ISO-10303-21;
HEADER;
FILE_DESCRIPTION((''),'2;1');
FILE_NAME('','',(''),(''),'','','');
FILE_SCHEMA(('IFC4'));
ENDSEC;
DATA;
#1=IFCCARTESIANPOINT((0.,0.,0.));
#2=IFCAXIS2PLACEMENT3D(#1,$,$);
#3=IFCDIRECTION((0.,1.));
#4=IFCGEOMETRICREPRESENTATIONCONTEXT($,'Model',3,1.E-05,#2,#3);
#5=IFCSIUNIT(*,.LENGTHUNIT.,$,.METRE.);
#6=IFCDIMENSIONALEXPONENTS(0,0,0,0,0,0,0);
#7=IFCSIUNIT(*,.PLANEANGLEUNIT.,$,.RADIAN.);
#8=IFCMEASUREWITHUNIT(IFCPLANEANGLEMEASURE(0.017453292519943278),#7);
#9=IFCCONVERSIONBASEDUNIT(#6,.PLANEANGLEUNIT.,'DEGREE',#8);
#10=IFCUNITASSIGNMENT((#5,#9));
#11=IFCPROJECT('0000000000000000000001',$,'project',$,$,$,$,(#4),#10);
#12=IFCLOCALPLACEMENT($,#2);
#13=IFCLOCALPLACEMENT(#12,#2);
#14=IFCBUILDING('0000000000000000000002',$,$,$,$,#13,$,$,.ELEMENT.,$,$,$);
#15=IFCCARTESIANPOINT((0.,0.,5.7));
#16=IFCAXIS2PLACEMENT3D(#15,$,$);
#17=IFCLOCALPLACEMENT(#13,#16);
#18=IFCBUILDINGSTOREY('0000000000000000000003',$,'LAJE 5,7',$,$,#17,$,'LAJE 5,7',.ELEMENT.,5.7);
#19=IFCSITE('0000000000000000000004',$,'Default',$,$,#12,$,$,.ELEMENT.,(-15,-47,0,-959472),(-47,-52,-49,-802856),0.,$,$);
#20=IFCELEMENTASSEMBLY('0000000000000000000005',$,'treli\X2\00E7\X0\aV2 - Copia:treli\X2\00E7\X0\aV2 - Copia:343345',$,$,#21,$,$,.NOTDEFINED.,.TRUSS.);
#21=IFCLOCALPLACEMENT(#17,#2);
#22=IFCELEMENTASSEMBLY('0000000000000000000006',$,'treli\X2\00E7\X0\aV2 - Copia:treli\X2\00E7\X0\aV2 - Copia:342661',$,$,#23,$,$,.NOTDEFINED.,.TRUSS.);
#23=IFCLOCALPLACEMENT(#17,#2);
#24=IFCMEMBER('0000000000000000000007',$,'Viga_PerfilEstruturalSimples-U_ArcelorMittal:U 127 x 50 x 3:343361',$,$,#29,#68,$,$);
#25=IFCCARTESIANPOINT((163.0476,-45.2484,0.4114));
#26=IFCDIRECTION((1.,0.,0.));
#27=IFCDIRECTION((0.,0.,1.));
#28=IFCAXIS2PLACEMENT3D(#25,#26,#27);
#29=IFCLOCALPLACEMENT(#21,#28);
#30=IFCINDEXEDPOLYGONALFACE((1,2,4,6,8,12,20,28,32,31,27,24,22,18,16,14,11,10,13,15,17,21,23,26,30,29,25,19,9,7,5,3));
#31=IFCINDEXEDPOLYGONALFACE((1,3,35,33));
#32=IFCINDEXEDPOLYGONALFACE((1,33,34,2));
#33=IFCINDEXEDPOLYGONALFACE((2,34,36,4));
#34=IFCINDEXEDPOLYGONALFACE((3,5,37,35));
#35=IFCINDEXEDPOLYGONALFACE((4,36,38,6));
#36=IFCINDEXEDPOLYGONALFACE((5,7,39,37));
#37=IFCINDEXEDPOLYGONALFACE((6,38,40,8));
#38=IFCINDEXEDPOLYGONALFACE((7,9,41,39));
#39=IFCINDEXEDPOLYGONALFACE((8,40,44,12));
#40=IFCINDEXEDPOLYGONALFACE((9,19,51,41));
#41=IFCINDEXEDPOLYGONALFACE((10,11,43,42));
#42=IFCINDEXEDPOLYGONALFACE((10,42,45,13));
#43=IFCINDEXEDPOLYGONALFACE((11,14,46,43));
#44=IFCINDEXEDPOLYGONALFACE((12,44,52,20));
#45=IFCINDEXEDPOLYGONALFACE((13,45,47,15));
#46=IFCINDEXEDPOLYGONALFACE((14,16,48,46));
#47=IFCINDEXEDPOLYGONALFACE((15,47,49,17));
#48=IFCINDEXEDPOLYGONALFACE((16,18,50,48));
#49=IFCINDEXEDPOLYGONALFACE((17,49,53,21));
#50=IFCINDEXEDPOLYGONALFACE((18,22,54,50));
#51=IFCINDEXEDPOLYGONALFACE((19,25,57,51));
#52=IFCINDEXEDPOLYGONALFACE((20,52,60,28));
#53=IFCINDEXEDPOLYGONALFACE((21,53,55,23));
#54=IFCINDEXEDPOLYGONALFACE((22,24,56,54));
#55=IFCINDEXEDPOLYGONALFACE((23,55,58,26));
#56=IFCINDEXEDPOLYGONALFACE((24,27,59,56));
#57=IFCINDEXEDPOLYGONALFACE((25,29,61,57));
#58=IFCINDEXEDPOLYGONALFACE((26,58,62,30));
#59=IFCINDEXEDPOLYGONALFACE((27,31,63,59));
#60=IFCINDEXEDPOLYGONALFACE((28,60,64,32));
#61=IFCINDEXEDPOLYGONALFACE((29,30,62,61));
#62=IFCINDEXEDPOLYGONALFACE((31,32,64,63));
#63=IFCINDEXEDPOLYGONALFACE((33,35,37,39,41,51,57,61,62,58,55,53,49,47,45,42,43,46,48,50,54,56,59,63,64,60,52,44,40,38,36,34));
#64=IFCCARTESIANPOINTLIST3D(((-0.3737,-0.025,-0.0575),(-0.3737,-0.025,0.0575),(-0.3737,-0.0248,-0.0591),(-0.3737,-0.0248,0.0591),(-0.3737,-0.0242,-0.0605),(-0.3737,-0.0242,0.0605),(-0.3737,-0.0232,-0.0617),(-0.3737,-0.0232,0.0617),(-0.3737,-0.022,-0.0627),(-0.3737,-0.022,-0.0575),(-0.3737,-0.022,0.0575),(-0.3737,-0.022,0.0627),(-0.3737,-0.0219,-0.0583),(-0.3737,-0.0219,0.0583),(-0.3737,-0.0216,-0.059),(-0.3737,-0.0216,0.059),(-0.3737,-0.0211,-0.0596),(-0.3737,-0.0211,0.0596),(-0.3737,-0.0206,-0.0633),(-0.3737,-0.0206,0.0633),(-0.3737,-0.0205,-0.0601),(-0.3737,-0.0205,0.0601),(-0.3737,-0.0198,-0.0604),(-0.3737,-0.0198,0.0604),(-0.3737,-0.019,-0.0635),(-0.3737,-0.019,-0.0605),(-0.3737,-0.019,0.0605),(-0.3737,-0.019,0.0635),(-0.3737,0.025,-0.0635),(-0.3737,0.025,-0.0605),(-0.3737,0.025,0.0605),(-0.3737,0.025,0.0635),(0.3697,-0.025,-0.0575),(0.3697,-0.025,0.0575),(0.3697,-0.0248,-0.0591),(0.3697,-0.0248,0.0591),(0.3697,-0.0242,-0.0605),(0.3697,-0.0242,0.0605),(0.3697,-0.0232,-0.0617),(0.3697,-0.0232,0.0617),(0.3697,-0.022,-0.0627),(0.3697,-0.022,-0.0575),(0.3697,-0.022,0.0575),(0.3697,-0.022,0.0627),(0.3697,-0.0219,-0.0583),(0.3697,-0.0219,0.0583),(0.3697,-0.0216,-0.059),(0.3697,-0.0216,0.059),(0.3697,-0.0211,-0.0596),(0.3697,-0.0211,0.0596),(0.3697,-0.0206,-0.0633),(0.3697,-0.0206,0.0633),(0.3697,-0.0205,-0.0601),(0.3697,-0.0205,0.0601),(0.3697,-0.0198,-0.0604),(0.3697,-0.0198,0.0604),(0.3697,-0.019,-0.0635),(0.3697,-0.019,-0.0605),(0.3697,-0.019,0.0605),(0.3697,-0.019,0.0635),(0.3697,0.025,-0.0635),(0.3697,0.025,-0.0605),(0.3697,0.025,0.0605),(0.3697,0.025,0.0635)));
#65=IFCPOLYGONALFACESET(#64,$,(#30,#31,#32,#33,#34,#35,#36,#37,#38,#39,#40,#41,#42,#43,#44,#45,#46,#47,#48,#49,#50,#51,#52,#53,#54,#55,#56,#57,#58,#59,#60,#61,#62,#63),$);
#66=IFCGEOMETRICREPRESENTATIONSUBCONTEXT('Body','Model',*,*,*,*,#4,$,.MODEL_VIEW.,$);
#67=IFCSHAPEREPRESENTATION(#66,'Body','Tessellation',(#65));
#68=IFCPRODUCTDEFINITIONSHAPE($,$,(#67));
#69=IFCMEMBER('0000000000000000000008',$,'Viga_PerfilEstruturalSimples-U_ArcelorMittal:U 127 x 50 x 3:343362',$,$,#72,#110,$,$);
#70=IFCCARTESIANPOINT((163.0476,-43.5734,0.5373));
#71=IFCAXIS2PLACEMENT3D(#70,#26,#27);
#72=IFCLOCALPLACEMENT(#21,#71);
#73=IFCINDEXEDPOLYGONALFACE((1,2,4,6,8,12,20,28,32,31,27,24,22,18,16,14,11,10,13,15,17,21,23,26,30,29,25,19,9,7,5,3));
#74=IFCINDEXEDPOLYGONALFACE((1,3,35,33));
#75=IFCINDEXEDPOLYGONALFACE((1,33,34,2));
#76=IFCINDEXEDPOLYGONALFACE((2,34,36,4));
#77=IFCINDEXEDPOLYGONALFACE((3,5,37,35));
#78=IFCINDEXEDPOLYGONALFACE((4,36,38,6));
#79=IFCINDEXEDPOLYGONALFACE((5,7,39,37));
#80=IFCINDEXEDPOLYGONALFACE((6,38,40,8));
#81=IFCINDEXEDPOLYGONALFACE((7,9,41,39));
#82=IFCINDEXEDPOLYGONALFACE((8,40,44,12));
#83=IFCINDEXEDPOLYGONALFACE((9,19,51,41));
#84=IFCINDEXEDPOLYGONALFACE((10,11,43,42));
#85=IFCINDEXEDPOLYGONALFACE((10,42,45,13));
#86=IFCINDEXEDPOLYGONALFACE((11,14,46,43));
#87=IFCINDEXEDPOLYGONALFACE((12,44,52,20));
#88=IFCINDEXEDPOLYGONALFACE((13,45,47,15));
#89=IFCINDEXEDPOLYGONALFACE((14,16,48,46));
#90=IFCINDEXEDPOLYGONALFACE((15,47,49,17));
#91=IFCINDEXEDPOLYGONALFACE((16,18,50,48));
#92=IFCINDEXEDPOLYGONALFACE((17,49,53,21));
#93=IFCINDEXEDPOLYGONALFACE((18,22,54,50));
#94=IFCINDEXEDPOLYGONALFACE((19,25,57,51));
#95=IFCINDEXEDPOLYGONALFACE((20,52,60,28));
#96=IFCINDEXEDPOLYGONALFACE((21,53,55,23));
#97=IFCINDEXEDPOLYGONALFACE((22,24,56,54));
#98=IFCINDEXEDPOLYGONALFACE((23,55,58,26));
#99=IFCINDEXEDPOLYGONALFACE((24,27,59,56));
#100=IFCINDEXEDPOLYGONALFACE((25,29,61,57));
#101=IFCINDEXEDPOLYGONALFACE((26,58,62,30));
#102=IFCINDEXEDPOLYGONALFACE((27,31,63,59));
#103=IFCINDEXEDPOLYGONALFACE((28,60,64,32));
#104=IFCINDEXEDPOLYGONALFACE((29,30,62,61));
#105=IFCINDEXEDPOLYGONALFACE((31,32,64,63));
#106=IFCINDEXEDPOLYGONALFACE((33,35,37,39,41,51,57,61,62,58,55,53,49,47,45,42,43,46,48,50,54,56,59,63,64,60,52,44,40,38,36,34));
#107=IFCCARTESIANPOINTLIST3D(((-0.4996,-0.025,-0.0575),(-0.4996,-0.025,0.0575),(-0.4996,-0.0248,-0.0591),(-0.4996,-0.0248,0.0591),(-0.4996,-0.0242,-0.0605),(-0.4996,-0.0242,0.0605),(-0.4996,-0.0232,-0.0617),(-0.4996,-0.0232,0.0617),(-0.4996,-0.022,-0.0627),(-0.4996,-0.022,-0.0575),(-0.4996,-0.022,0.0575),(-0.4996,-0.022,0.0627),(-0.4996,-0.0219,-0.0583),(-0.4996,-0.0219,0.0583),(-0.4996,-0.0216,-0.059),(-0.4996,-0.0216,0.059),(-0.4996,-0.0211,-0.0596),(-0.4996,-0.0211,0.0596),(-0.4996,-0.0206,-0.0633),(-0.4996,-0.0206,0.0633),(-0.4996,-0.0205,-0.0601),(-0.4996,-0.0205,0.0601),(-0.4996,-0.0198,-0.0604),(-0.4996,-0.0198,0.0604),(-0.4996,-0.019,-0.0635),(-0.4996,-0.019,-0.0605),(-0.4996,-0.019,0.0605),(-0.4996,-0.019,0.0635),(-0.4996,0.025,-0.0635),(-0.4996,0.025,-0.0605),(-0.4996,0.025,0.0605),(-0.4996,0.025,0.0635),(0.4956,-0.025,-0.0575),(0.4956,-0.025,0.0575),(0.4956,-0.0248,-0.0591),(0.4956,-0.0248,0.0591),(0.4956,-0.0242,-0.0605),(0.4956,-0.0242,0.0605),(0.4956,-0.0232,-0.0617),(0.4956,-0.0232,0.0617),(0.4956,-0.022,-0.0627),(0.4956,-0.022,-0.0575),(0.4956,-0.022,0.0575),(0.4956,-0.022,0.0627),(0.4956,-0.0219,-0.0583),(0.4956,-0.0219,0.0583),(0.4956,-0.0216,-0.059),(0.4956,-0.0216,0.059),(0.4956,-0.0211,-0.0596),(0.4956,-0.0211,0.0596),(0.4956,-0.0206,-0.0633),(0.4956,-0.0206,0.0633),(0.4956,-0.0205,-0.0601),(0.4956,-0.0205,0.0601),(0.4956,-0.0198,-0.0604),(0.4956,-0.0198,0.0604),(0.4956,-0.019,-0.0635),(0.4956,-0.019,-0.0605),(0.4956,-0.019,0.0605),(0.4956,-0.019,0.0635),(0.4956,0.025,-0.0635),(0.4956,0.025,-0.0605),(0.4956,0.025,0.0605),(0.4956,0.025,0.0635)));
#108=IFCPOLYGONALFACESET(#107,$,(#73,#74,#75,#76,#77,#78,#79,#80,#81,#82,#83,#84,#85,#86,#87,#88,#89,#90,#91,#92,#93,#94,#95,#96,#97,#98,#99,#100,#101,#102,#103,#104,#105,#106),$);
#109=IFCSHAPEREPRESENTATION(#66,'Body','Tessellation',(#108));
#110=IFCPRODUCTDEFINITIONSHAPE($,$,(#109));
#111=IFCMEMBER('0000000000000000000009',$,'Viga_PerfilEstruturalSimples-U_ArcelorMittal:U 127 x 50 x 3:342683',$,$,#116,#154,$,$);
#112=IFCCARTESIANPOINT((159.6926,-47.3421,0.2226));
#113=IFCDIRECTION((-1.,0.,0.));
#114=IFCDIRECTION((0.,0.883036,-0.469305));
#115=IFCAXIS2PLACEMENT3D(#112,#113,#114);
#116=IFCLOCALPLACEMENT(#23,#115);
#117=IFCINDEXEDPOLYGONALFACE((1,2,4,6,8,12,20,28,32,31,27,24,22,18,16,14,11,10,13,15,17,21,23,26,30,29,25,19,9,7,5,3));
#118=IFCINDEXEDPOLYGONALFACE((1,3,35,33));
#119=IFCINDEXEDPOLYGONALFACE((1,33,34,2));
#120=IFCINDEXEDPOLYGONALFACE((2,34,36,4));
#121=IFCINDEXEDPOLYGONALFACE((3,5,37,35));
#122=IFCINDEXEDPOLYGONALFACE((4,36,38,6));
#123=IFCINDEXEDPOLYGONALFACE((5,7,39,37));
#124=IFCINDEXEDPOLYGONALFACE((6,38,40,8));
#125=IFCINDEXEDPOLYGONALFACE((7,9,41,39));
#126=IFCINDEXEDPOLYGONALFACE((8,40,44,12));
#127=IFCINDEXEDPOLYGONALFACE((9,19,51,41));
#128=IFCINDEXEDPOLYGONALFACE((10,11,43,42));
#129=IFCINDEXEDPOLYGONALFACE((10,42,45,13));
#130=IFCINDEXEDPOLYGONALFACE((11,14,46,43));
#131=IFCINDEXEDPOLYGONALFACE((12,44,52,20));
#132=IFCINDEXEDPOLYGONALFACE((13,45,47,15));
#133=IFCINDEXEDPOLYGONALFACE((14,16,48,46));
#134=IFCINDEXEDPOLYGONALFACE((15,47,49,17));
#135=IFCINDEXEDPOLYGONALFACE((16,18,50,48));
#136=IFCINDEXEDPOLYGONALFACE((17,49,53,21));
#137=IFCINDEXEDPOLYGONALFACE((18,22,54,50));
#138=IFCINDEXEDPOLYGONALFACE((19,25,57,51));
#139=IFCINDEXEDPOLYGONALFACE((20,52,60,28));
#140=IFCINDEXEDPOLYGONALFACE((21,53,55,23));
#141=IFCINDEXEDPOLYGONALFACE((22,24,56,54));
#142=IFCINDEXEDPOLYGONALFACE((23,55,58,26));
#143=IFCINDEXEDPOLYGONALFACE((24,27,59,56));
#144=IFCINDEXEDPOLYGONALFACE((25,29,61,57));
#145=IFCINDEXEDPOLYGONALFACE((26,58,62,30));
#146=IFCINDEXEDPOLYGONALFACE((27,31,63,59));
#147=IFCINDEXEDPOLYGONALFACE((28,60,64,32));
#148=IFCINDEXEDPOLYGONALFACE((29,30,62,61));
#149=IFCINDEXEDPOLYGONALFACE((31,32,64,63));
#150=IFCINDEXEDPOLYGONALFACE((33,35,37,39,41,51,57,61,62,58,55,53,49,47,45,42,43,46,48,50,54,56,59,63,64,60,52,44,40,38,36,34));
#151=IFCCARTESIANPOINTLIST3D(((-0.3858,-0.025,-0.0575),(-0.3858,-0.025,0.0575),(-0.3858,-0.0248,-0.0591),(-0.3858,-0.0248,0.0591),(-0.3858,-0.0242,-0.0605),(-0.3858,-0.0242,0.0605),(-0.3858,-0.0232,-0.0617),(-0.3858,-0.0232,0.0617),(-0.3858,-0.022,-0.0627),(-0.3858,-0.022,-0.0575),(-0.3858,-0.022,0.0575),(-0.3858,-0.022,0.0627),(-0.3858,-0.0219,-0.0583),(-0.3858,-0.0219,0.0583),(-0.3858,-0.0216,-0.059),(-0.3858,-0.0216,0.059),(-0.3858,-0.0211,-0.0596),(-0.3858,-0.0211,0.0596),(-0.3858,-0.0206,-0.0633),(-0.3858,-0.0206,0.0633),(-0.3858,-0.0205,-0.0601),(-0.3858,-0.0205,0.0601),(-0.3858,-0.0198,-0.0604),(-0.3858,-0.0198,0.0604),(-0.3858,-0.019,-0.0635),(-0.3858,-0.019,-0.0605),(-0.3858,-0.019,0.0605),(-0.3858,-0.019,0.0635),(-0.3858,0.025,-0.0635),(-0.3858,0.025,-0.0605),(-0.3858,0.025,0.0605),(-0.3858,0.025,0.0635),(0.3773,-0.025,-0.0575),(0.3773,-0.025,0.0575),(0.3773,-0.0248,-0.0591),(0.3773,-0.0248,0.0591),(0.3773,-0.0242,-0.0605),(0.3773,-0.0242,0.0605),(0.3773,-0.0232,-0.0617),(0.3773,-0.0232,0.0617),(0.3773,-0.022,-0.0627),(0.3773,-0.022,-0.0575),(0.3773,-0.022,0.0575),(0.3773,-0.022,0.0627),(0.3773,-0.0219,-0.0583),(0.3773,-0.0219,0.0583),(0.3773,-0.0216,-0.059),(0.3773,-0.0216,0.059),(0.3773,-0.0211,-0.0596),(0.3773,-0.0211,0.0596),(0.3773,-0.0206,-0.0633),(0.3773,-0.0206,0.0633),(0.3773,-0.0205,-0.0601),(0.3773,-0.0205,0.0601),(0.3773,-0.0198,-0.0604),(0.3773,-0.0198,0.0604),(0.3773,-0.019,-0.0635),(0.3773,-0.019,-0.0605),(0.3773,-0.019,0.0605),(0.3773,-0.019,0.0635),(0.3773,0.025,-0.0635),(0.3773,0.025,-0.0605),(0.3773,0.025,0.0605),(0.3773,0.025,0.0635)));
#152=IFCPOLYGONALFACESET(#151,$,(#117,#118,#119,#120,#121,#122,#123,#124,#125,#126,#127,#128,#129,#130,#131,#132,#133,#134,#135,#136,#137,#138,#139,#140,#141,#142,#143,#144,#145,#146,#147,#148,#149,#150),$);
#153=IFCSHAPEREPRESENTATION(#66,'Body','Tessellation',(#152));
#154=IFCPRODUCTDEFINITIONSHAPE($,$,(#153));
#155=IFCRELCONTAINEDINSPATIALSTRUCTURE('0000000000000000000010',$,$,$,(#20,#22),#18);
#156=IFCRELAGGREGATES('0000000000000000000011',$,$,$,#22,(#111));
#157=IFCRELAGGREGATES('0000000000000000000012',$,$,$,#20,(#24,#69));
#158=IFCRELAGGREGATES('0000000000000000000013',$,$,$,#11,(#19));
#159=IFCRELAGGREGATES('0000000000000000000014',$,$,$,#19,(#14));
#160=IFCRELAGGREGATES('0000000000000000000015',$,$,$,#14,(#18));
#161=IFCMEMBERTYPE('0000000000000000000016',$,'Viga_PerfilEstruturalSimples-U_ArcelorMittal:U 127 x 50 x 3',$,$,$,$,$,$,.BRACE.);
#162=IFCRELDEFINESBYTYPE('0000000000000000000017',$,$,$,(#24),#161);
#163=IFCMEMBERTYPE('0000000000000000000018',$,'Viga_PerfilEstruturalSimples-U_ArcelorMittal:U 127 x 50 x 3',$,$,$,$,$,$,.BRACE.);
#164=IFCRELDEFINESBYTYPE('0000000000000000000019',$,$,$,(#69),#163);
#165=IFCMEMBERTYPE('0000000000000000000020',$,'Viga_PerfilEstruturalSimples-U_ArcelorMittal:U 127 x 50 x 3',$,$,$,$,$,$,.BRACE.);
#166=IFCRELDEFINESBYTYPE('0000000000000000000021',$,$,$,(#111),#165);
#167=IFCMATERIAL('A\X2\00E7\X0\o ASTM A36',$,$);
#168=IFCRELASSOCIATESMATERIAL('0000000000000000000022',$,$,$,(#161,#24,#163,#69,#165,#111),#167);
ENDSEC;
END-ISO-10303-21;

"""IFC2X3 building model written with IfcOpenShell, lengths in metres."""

from ifc_helpers import new_model, entity, si_unit, converted_unit, direction, frame, frame_2d, origin, place, context, subcontext, project, spatial, polyline, circle_curve, parameter, trimmed, segment, composite_curve, outline, extrude, source, transform, mapped, material, type_object, type_shapes, element, aggregate, save


model = new_model("IFC2X3")

# Units and contexts
model_context = context("Model", 3, precision=1e-05, world=origin(), true_north=direction((0.0, 1.0)))
body_context = subcontext(model_context, "Body", "Model", "MODEL_VIEW")
ifc_project = project(units=[si_unit("LENGTHUNIT", "METRE"), converted_unit("PLANEANGLEUNIT", "DEGREE", entity("IfcPlaneAngleMeasure", 0.017453292519943278), si_unit("PLANEANGLEUNIT", "RADIAN"), dimensions=[0, 0, 0, 0, 0, 0, 0])], contexts=[model_context])

# Site, building, storey
site_placement = place(None, origin())
site = spatial("IfcSite", under=ifc_project, at=site_placement, Name="Default", CompositionType="ELEMENT", RefLatitude=(-15, -47, 0, -959472), RefLongitude=(-47, -52, -49, -802856), RefElevation=0.0)
building_placement = place(site_placement, origin())
building = spatial("IfcBuilding", under=site, at=building_placement, CompositionType="ELEMENT")
storey_placement = place(building_placement, frame((0.0, 0.0, 5.7)))
storey = spatial("IfcBuildingStorey", under=building, at=storey_placement, Name="LAJE 5,7", LongName="LAJE 5,7", CompositionType="ELEMENT", Elevation=5.7)

# Element assembly
assembly_1_placement = place(storey_placement, origin())
assembly_1 = element("IfcElementAssembly", 1, at=assembly_1_placement, inside=storey, Name="treliçaV2 - Copia:treliçaV2 - Copia:343345", AssemblyPlace="NOTDEFINED", PredefinedType="TRUSS")
ifc_material = material(Name="Aço ASTM A36")

# Element assembly
assembly_2_placement = place(storey_placement, origin())
assembly_2 = element("IfcElementAssembly", 2, at=assembly_2_placement, inside=storey, Name="treliçaV2 - Copia:treliçaV2 - Copia:342661", AssemblyPlace="NOTDEFINED", PredefinedType="TRUSS")

# Members
member_type_1 = type_object("IfcMemberType", Name="Viga_PerfilEstruturalSimples-U_ArcelorMittal:U 127 x 50 x 3", PredefinedType="BRACE", material=ifc_material)
shared_shape_1 = source(origin(), body_context, "Body", "SweptSolid", [
    extrude(outline(composite_curve([segment(polyline([(-0.0575, -0.0192), (0.0575, -0.0192)]), True, "CONTINUOUS"), segment(trimmed(circle_curve(frame_2d((0.0575, -0.0132), x_axis=(0.0, 1.0)), 0.006), [parameter(180.0)], [parameter(270.0)], True, "PARAMETER"), True, "CONTINUOUS"), segment(polyline([(0.0635, -0.0132), (0.0635, 0.0308)]), True, "CONTINUOUS"), segment(polyline([(0.0635, 0.0308), (0.0605, 0.0308)]), True, "CONTINUOUS"), segment(polyline([(0.0605, 0.0308), (0.0605, -0.0132)]), True, "CONTINUOUS"), segment(trimmed(circle_curve(frame_2d((0.0575, -0.0132), x_axis=(0.0, 1.0)), 0.003), [parameter(180.0)], [parameter(270.0)], True, "PARAMETER"), False, "CONTINUOUS"), segment(polyline([(0.0575, -0.0162), (-0.0575, -0.0162)]), True, "CONTINUOUS"), segment(trimmed(circle_curve(frame_2d((-0.0575, -0.0132), x_axis=(0.0, 1.0)), 0.003), [parameter(90.0)], [parameter(180.0)], True, "PARAMETER"), False, "CONTINUOUS"), segment(polyline([(-0.0605, -0.0132), (-0.0605, 0.0308)]), True, "CONTINUOUS"), segment(polyline([(-0.0605, 0.0308), (-0.0635, 0.0308)]), True, "CONTINUOUS"), segment(polyline([(-0.0635, 0.0308), (-0.0635, -0.0132)]), True, "CONTINUOUS"), segment(trimmed(circle_curve(frame_2d((-0.0575, -0.0132), x_axis=(0.0, 1.0)), 0.006), [parameter(90.0)], [parameter(180.0)], True, "PARAMETER"), True, "CONTINUOUS")], self_intersect=False)), frame((-0.3737, -0.0058, 0.0), z_axis=(1.0, 0.0, 0.0), x_axis=(0.0, 0.0, -1.0)), (0.0, 0.0, 1.0), 0.7434),
])
type_shapes(member_type_1, [shared_shape_1])
member_1_placement = place(assembly_1_placement, frame((163.0476, -45.2484, 0.4114), z_axis=(1.0, 0.0, 0.0), x_axis=(0.0, 0.0, 1.0)))
member_1 = element("IfcMember", 3, at=member_1_placement, type_object=member_type_1, material=ifc_material, Name="Viga_PerfilEstruturalSimples-U_ArcelorMittal:U 127 x 50 x 3:343361", context=body_context, shape_type="MappedRepresentation", body=[
    mapped(shared_shape_1, transform((0.0, 0.0, 0.0), scale=1.0)),
])
member_type_2 = type_object("IfcMemberType", Name="Viga_PerfilEstruturalSimples-U_ArcelorMittal:U 127 x 50 x 3", PredefinedType="BRACE", material=ifc_material)
shared_shape_2 = source(origin(), body_context, "Body", "SweptSolid", [
    extrude(outline(composite_curve([segment(polyline([(-0.0575, -0.0192), (0.0575, -0.0192)]), True, "CONTINUOUS"), segment(trimmed(circle_curve(frame_2d((0.0575, -0.0132), x_axis=(0.0, 1.0)), 0.006), [parameter(180.0)], [parameter(270.0)], True, "PARAMETER"), True, "CONTINUOUS"), segment(polyline([(0.0635, -0.0132), (0.0635, 0.0308)]), True, "CONTINUOUS"), segment(polyline([(0.0635, 0.0308), (0.0605, 0.0308)]), True, "CONTINUOUS"), segment(polyline([(0.0605, 0.0308), (0.0605, -0.0132)]), True, "CONTINUOUS"), segment(trimmed(circle_curve(frame_2d((0.0575, -0.0132), x_axis=(0.0, 1.0)), 0.003), [parameter(180.0)], [parameter(270.0)], True, "PARAMETER"), False, "CONTINUOUS"), segment(polyline([(0.0575, -0.0162), (-0.0575, -0.0162)]), True, "CONTINUOUS"), segment(trimmed(circle_curve(frame_2d((-0.0575, -0.0132), x_axis=(0.0, 1.0)), 0.003), [parameter(90.0)], [parameter(180.0)], True, "PARAMETER"), False, "CONTINUOUS"), segment(polyline([(-0.0605, -0.0132), (-0.0605, 0.0308)]), True, "CONTINUOUS"), segment(polyline([(-0.0605, 0.0308), (-0.0635, 0.0308)]), True, "CONTINUOUS"), segment(polyline([(-0.0635, 0.0308), (-0.0635, -0.0132)]), True, "CONTINUOUS"), segment(trimmed(circle_curve(frame_2d((-0.0575, -0.0132), x_axis=(0.0, 1.0)), 0.006), [parameter(90.0)], [parameter(180.0)], True, "PARAMETER"), True, "CONTINUOUS")], self_intersect=False)), frame((-0.4996, -0.0058, 0.0), z_axis=(1.0, 0.0, 0.0), x_axis=(0.0, 0.0, -1.0)), (0.0, 0.0, 1.0), 0.9952),
])
type_shapes(member_type_2, [shared_shape_2])
member_2_placement = place(assembly_1_placement, frame((163.0476, -43.5734, 0.5373), z_axis=(1.0, 0.0, 0.0), x_axis=(0.0, 0.0, 1.0)))
member_2 = element("IfcMember", 4, at=member_2_placement, type_object=member_type_2, material=ifc_material, Name="Viga_PerfilEstruturalSimples-U_ArcelorMittal:U 127 x 50 x 3:343362", context=body_context, shape_type="MappedRepresentation", body=[
    mapped(shared_shape_2, transform((0.0, 0.0, 0.0), scale=1.0)),
])
member_type_3 = type_object("IfcMemberType", Name="Viga_PerfilEstruturalSimples-U_ArcelorMittal:U 127 x 50 x 3", PredefinedType="BRACE", material=ifc_material)
shared_shape_3 = source(origin(), body_context, "Body", "SweptSolid", [
    extrude(outline(composite_curve([segment(polyline([(-0.0575, -0.0192), (0.0575, -0.0192)]), True, "CONTINUOUS"), segment(trimmed(circle_curve(frame_2d((0.0575, -0.0132), x_axis=(0.0, 1.0)), 0.006), [parameter(180.0)], [parameter(270.0)], True, "PARAMETER"), True, "CONTINUOUS"), segment(polyline([(0.0635, -0.0132), (0.0635, 0.0308)]), True, "CONTINUOUS"), segment(polyline([(0.0635, 0.0308), (0.0605, 0.0308)]), True, "CONTINUOUS"), segment(polyline([(0.0605, 0.0308), (0.0605, -0.0132)]), True, "CONTINUOUS"), segment(trimmed(circle_curve(frame_2d((0.0575, -0.0132), x_axis=(0.0, 1.0)), 0.003), [parameter(180.0)], [parameter(270.0)], True, "PARAMETER"), False, "CONTINUOUS"), segment(polyline([(0.0575, -0.0162), (-0.0575, -0.0162)]), True, "CONTINUOUS"), segment(trimmed(circle_curve(frame_2d((-0.0575, -0.0132), x_axis=(0.0, 1.0)), 0.003), [parameter(90.0)], [parameter(180.0)], True, "PARAMETER"), False, "CONTINUOUS"), segment(polyline([(-0.0605, -0.0132), (-0.0605, 0.0308)]), True, "CONTINUOUS"), segment(polyline([(-0.0605, 0.0308), (-0.0635, 0.0308)]), True, "CONTINUOUS"), segment(polyline([(-0.0635, 0.0308), (-0.0635, -0.0132)]), True, "CONTINUOUS"), segment(trimmed(circle_curve(frame_2d((-0.0575, -0.0132), x_axis=(0.0, 1.0)), 0.006), [parameter(90.0)], [parameter(180.0)], True, "PARAMETER"), True, "CONTINUOUS")], self_intersect=False)), frame((-0.3858, -0.0058, 0.0), z_axis=(1.0, 0.0, 0.0), x_axis=(0.0, 0.0, -1.0)), (0.0, 0.0, 1.0), 0.7631),
])
type_shapes(member_type_3, [shared_shape_3])
member_3_placement = place(assembly_2_placement, frame((159.6926, -47.3421, 0.2226), z_axis=(-1.0, 0.0, 0.0), x_axis=(0.0, 0.883036, -0.469305)))
member_3 = element("IfcMember", 5, at=member_3_placement, type_object=member_type_3, material=ifc_material, Name="Viga_PerfilEstruturalSimples-U_ArcelorMittal:U 127 x 50 x 3:342683", context=body_context, shape_type="MappedRepresentation", body=[
    mapped(shared_shape_3, transform((0.0, 0.0, 0.0), scale=1.0)),
])
aggregate(assembly_2, [member_3])
aggregate(assembly_1, [member_1, member_2])

save(model, "model.ifc")
